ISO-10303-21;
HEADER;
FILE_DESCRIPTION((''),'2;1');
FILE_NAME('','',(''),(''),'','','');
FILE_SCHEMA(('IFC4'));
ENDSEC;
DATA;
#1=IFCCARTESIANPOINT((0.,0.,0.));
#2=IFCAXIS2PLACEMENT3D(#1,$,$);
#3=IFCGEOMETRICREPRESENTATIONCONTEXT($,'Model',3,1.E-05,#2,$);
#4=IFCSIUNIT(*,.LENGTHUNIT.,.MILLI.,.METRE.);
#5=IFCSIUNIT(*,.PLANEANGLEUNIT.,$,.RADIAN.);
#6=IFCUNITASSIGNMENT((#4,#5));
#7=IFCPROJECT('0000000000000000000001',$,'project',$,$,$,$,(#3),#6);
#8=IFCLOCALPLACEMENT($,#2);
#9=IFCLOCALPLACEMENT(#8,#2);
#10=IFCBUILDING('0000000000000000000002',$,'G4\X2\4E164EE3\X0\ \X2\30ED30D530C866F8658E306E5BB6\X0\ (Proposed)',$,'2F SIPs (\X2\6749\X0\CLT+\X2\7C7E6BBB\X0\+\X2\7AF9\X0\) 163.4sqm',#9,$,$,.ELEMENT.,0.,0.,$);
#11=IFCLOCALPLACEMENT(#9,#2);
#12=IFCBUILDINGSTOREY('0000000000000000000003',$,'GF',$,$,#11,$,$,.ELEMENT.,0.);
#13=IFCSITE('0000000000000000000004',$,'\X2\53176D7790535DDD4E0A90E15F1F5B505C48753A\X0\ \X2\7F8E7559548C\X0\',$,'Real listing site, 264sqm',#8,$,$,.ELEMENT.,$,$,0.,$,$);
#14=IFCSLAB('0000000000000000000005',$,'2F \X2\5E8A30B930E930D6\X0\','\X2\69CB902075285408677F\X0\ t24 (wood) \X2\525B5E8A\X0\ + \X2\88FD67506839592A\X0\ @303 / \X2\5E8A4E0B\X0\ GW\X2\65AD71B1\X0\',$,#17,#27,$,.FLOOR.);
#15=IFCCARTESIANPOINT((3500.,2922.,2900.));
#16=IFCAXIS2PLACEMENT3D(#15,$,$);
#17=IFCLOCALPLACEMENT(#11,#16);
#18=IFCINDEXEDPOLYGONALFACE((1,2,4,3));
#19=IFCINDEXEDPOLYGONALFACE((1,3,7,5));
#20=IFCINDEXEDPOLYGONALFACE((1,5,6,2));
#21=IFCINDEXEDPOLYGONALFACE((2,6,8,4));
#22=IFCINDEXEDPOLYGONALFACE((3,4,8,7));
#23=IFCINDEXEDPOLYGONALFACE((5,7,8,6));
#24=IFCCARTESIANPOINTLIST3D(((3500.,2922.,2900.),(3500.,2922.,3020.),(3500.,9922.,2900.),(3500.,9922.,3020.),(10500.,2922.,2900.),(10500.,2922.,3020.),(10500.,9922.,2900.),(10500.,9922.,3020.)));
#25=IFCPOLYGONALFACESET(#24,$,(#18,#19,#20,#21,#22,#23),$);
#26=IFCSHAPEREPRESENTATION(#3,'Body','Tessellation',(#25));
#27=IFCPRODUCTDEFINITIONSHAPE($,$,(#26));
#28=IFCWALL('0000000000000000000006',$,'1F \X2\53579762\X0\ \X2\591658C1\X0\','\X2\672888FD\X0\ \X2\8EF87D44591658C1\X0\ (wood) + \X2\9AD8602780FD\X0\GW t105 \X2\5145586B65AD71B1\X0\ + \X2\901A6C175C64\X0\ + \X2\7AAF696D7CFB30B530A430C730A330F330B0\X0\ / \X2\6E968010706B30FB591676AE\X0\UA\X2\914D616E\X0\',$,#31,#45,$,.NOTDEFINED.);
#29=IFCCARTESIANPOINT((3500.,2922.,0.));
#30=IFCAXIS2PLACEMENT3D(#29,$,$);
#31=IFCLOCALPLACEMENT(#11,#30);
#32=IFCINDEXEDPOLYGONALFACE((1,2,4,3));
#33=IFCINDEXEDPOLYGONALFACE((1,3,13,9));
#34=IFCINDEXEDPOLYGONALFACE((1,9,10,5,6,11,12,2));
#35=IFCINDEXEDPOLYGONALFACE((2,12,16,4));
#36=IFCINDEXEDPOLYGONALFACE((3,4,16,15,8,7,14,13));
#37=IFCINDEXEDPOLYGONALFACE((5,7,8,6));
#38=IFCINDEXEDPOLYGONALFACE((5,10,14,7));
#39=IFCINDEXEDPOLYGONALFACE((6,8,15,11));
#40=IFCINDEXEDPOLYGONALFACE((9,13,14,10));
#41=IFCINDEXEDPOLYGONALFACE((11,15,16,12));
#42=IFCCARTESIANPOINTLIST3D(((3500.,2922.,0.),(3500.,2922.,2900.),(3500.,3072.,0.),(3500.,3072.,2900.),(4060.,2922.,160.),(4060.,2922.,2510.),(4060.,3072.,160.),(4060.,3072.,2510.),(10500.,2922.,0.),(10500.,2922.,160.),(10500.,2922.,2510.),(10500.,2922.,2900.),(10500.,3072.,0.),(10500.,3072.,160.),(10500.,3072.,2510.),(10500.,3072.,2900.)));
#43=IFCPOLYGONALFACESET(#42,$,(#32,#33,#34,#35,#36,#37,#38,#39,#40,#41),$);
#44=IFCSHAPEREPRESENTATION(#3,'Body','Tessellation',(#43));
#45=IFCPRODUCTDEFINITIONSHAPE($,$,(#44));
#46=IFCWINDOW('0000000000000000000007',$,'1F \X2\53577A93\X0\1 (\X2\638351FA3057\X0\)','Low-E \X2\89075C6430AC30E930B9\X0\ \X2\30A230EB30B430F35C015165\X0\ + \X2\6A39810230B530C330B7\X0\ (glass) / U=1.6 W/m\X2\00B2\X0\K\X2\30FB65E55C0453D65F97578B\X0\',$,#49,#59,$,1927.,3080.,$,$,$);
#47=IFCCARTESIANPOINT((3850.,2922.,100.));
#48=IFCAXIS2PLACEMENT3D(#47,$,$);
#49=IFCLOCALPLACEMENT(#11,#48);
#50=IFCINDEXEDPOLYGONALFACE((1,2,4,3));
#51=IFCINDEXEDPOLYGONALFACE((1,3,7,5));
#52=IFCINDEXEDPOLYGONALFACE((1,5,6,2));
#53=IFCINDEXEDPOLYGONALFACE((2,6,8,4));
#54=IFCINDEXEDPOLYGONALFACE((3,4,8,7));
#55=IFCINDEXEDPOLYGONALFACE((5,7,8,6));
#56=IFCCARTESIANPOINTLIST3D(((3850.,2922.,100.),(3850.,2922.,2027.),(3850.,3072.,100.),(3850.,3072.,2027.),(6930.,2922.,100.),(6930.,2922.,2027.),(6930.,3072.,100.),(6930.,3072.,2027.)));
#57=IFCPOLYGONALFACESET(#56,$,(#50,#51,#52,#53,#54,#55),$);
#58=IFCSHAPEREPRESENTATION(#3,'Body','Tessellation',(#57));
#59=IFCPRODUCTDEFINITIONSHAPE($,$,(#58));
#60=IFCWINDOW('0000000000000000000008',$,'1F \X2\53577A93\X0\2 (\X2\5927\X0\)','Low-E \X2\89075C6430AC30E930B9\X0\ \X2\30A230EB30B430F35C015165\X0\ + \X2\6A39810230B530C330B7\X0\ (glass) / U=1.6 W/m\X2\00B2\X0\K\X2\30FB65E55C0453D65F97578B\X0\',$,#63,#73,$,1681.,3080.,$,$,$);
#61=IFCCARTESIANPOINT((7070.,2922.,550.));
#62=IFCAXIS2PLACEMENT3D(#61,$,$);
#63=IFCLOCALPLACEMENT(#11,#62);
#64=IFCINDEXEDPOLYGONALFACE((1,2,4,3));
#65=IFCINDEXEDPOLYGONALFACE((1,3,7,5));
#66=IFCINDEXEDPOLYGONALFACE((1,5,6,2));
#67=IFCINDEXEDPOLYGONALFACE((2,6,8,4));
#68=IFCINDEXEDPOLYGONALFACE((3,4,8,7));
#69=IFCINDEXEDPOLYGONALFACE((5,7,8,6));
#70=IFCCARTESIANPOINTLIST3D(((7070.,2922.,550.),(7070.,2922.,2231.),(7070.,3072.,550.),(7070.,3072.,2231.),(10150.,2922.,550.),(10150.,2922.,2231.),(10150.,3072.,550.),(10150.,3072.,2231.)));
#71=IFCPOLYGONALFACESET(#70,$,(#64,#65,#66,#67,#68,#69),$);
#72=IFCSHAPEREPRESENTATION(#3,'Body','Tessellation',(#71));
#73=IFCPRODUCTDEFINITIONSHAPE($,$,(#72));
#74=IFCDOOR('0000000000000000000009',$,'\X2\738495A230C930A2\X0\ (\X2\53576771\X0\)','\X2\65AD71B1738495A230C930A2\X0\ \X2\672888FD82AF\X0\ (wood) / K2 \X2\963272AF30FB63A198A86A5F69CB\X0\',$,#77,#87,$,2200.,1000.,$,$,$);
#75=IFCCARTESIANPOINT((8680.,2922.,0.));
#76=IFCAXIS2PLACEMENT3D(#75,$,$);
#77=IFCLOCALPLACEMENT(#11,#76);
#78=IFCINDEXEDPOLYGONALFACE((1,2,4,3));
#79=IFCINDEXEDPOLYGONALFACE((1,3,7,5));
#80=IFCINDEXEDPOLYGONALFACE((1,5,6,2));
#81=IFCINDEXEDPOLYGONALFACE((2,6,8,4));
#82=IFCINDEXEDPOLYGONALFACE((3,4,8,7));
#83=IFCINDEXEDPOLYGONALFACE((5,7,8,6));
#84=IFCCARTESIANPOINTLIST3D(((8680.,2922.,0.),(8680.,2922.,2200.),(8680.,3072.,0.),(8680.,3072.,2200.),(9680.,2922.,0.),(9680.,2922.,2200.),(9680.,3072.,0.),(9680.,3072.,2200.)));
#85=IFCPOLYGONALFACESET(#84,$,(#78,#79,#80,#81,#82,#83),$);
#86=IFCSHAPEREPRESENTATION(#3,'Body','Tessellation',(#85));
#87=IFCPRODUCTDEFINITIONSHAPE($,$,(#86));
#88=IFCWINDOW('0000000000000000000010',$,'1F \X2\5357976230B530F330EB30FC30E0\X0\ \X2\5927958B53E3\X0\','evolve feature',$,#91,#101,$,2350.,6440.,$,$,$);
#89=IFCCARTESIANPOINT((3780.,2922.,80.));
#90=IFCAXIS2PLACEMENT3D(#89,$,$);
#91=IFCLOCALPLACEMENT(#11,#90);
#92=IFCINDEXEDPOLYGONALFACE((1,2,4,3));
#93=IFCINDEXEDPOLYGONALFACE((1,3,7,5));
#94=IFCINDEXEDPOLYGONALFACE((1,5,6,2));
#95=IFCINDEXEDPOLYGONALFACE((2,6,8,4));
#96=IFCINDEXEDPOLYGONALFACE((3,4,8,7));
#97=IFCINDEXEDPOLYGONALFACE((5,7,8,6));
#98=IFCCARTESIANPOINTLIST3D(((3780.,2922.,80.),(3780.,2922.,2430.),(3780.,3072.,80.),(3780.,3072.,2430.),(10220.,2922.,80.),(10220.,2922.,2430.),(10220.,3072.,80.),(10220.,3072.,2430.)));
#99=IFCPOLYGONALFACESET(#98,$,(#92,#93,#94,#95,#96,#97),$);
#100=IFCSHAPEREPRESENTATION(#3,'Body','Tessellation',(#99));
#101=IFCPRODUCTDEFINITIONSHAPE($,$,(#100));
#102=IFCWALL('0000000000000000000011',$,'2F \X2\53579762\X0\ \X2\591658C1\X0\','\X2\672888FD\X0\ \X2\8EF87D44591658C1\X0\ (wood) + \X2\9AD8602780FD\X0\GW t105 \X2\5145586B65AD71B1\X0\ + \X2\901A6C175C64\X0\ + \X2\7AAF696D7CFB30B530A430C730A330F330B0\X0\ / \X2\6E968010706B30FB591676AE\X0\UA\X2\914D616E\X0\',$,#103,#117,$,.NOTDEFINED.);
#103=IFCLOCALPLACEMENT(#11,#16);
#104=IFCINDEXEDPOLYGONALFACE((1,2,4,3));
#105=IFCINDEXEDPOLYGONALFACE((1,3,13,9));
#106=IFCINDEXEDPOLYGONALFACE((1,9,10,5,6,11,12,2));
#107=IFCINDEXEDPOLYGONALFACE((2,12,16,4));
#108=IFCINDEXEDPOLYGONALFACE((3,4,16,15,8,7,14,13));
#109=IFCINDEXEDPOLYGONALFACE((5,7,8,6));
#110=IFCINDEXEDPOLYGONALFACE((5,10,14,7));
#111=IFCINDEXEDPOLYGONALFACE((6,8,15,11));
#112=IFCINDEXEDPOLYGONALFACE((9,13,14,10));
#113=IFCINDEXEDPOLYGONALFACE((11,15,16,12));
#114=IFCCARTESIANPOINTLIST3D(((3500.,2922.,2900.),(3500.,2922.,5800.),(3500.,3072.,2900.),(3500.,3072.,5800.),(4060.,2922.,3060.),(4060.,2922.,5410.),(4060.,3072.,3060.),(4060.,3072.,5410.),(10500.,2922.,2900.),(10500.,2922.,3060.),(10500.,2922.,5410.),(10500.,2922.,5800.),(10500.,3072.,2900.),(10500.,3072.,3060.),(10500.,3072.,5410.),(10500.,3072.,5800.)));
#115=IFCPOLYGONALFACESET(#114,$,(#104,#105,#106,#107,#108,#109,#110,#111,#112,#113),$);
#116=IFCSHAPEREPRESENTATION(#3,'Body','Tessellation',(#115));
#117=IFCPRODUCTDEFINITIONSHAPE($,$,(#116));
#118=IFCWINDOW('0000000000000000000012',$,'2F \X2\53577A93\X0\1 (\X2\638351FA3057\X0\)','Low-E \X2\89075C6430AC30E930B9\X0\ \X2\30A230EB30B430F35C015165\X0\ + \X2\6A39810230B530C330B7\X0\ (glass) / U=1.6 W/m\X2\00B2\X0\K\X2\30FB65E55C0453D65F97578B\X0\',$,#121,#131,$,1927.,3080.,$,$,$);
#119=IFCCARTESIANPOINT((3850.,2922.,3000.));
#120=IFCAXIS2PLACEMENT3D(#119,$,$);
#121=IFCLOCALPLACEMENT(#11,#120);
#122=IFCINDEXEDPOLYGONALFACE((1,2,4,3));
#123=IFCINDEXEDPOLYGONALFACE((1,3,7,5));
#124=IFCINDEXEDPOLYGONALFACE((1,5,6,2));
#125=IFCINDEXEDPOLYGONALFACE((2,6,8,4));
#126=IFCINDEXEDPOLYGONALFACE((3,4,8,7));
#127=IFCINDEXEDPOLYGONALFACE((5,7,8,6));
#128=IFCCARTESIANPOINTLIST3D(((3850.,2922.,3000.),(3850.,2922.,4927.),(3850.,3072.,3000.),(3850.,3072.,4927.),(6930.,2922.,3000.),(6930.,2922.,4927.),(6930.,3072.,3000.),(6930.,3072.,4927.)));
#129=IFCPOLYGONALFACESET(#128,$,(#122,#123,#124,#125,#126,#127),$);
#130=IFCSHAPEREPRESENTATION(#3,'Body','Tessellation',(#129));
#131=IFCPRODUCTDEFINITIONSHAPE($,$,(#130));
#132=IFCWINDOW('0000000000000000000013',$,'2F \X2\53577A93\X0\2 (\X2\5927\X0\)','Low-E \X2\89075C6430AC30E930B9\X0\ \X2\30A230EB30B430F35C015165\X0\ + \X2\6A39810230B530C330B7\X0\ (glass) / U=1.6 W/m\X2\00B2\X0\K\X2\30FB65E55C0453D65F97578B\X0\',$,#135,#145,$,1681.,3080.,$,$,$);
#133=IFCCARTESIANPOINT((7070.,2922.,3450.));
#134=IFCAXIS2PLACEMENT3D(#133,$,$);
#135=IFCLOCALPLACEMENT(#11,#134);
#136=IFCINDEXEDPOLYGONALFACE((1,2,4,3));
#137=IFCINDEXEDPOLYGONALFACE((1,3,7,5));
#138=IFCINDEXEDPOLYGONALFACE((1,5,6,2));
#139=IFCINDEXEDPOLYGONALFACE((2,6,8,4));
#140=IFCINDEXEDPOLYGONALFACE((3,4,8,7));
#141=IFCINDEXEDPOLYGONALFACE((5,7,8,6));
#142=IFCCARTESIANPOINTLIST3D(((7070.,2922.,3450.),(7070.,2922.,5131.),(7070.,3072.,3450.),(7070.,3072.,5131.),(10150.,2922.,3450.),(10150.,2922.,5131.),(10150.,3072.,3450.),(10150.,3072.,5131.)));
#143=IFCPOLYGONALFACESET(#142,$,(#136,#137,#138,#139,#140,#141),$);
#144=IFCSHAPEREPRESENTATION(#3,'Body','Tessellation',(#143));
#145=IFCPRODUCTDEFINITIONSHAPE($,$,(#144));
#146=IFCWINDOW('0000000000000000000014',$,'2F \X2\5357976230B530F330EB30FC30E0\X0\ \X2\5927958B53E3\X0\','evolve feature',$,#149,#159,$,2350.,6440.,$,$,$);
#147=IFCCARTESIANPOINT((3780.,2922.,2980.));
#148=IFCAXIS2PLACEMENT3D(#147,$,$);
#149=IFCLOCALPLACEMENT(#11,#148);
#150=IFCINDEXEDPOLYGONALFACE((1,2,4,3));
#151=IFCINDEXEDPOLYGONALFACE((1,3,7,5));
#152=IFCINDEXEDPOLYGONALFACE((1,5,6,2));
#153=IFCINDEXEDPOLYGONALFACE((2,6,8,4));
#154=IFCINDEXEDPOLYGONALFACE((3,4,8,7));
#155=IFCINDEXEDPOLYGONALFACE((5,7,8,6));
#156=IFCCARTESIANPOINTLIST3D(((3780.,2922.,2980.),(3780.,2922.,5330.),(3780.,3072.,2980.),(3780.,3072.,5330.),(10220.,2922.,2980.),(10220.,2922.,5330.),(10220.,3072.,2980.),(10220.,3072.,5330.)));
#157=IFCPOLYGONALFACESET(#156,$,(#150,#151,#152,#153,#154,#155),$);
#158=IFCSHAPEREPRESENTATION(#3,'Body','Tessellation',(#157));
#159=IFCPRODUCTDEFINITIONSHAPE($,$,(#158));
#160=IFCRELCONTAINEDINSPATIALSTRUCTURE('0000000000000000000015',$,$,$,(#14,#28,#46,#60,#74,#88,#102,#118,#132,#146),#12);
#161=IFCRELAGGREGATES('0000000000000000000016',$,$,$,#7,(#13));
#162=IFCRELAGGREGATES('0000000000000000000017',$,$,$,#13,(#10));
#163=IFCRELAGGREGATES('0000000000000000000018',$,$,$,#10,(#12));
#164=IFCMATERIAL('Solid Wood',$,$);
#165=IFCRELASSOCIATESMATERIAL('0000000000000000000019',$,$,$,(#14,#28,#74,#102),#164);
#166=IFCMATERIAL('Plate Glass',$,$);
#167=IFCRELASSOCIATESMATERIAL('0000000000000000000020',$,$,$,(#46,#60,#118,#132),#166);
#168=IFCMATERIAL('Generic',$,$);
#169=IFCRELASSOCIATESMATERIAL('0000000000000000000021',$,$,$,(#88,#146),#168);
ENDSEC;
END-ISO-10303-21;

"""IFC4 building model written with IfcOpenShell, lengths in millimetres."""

from ifc_helpers import new_model, si_unit, frame, frame_2d, origin, place, context, project, spatial, rectangle, extrude, material, element, fill, save


model = new_model("IFC4")

# Units and contexts
model_context = context("Model", 3, precision=1e-05, world=origin())
ifc_project = project(units=[si_unit("LENGTHUNIT", "METRE", prefix="MILLI"), si_unit("PLANEANGLEUNIT", "RADIAN")], contexts=[model_context])

# Site, building, storey
site_placement = place(None, origin())
site = spatial("IfcSite", under=ifc_project, at=site_placement, Name="北海道川上郡弟子屈町 美留和", ObjectType="Real listing site, 264sqm", CompositionType="ELEMENT", RefElevation=0.0)
building_placement = place(site_placement, origin())
building = spatial("IfcBuilding", under=site, at=building_placement, Name="G4世代 ロフト書斎の家 (Proposed)", ObjectType="2F SIPs (杉CLT+籾殻+竹) 163.4sqm", CompositionType="ELEMENT", ElevationOfRefHeight=0.0, ElevationOfTerrain=0.0)
storey_placement = place(building_placement, origin())
storey = spatial("IfcBuildingStorey", under=building, at=storey_placement, Name="GF", CompositionType="ELEMENT", Elevation=0.0)

# Slab
ifc_material_1 = material(Name="Solid Wood")
slab_1_placement = place(storey_placement, frame((3500.0, 2922.0, 2900.0)))
element("IfcSlab", 1, at=slab_1_placement, inside=storey, material=ifc_material_1, Name="2F 床スラブ", Description="構造用合板 t24 (wood) 剛床 + 製材根太 @303 / 床下 GW断熱", PredefinedType="FLOOR", context=model_context, shape_type="SweptSolid", body=[
    extrude(rectangle(XDim=7000.0, YDim=7000.0, at=frame_2d((3500.0, 3500.0))), frame((3500.0, 2922.0, 2900.0)), (0.0, 0.0, 1.0), 120.0),
])
ifc_material_2 = material(Name="Generic")

# Wall, openings, windows, door
wall_1_placement = place(storey_placement, frame((3500.0, 2922.0, 0.0)))
wall_1 = element("IfcWall", 2, at=wall_1_placement, inside=storey, material=ifc_material_1, Name="1F 南面 外壁", Description="木製 軸組外壁 (wood) + 高性能GW t105 充填断熱 + 通気層 + 窯業系サイディング / 準耐火・外皮UA配慮", PredefinedType="NOTDEFINED", context=model_context, shape_type="SweptSolid", body=[
    extrude(rectangle(XDim=7000.0, YDim=150.0, at=frame_2d((3500.0, 75.0))), frame((3500.0, 2922.0, 0.0)), (0.0, 0.0, 1.0), 2900.0),
])
opening_1_placement = place(storey_placement, frame((3850.0, 2922.0, 100.0)))
opening_1 = element("IfcOpeningElement", 3, at=opening_1_placement, cuts=wall_1, PredefinedType="NOTDEFINED", context=model_context, shape_type="SweptSolid", body=[
    extrude(rectangle(XDim=3080.0, YDim=150.0, at=frame_2d((1540.0, 75.0))), frame((3850.0, 2922.0, 100.0)), (0.0, 0.0, 1.0), 1927.0),
])
opening_2_placement = place(storey_placement, frame((7070.0, 2922.0, 550.0)))
opening_2 = element("IfcOpeningElement", 4, at=opening_2_placement, cuts=wall_1, PredefinedType="NOTDEFINED", context=model_context, shape_type="SweptSolid", body=[
    extrude(rectangle(XDim=3080.0, YDim=150.0, at=frame_2d((1540.0, 75.0))), frame((7070.0, 2922.0, 550.0)), (0.0, 0.0, 1.0), 1681.0),
])
opening_3_placement = place(storey_placement, frame((8680.0, 2922.0, 0.0)))
opening_3 = element("IfcOpeningElement", 5, at=opening_3_placement, cuts=wall_1, PredefinedType="NOTDEFINED", context=model_context, shape_type="SweptSolid", body=[
    extrude(rectangle(XDim=1000.0, YDim=150.0, at=frame_2d((500.0, 75.0))), frame((8680.0, 2922.0, 0.0)), (0.0, 0.0, 1.0), 2200.0),
])
opening_4_placement = place(storey_placement, frame((3780.0, 2922.0, 80.0)))
opening_4 = element("IfcOpeningElement", 6, at=opening_4_placement, cuts=wall_1, PredefinedType="NOTDEFINED", context=model_context, shape_type="SweptSolid", body=[
    extrude(rectangle(XDim=6440.0, YDim=150.0, at=frame_2d((3220.0, 75.0))), frame((3780.0, 2922.0, 80.0)), (0.0, 0.0, 1.0), 2350.0),
])
ifc_material_3 = material(Name="Plate Glass")
window_1_placement = place(storey_placement, frame((3850.0, 2922.0, 100.0)))
window_1 = element("IfcWindow", 7, at=window_1_placement, inside=storey, material=ifc_material_3, Name="1F 南窓1 (掃出し)", Description="Low-E 複層ガラス アルゴン封入 + 樹脂サッシ (glass) / U=1.6 W/m²K・日射取得型", OverallHeight=1927.0, OverallWidth=3080.0, context=model_context, shape_type="SweptSolid", body=[
    extrude(rectangle(XDim=3080.0, YDim=150.0, at=frame_2d((1540.0, 75.0))), frame((3850.0, 2922.0, 100.0)), (0.0, 0.0, 1.0), 1927.0),
])
fill(opening_1, window_1)
window_2_placement = place(storey_placement, frame((7070.0, 2922.0, 550.0)))
window_2 = element("IfcWindow", 8, at=window_2_placement, inside=storey, material=ifc_material_3, Name="1F 南窓2 (大)", Description="Low-E 複層ガラス アルゴン封入 + 樹脂サッシ (glass) / U=1.6 W/m²K・日射取得型", OverallHeight=1681.0, OverallWidth=3080.0, context=model_context, shape_type="SweptSolid", body=[
    extrude(rectangle(XDim=3080.0, YDim=150.0, at=frame_2d((1540.0, 75.0))), frame((7070.0, 2922.0, 550.0)), (0.0, 0.0, 1.0), 1681.0),
])
fill(opening_2, window_2)
door_placement = place(storey_placement, frame((8680.0, 2922.0, 0.0)))
door = element("IfcDoor", 9, at=door_placement, inside=storey, material=ifc_material_1, Name="玄関ドア (南東)", Description="断熱玄関ドア 木製芯 (wood) / K2 防犯・採風機構", OverallHeight=2200.0, OverallWidth=1000.0, context=model_context, shape_type="SweptSolid", body=[
    extrude(rectangle(XDim=1000.0, YDim=150.0, at=frame_2d((500.0, 75.0))), frame((8680.0, 2922.0, 0.0)), (0.0, 0.0, 1.0), 2200.0),
])
fill(opening_3, door)
window_3_placement = place(storey_placement, frame((3780.0, 2922.0, 80.0)))
window_3 = element("IfcWindow", 10, at=window_3_placement, inside=storey, material=ifc_material_2, Name="1F 南面サンルーム 大開口", Description="evolve feature", OverallHeight=2350.0, OverallWidth=6440.0, context=model_context, shape_type="SweptSolid", body=[
    extrude(rectangle(XDim=6440.0, YDim=150.0, at=frame_2d((3220.0, 75.0))), frame((3780.0, 2922.0, 80.0)), (0.0, 0.0, 1.0), 2350.0),
])
fill(opening_4, window_3)

# Wall, openings, windows
wall_2_placement = place(storey_placement, frame((3500.0, 2922.0, 2900.0)))
wall_2 = element("IfcWall", 11, at=wall_2_placement, inside=storey, material=ifc_material_1, Name="2F 南面 外壁", Description="木製 軸組外壁 (wood) + 高性能GW t105 充填断熱 + 通気層 + 窯業系サイディング / 準耐火・外皮UA配慮", PredefinedType="NOTDEFINED", context=model_context, shape_type="SweptSolid", body=[
    extrude(rectangle(XDim=7000.0, YDim=150.0, at=frame_2d((3500.0, 75.0))), frame((3500.0, 2922.0, 2900.0)), (0.0, 0.0, 1.0), 2900.0),
])
opening_5_placement = place(storey_placement, frame((3850.0, 2922.0, 3000.0)))
opening_5 = element("IfcOpeningElement", 12, at=opening_5_placement, cuts=wall_2, PredefinedType="NOTDEFINED", context=model_context, shape_type="SweptSolid", body=[
    extrude(rectangle(XDim=3080.0, YDim=150.0, at=frame_2d((1540.0, 75.0))), frame((3850.0, 2922.0, 3000.0)), (0.0, 0.0, 1.0), 1927.0),
])
opening_6_placement = place(storey_placement, frame((7070.0, 2922.0, 3450.0)))
opening_6 = element("IfcOpeningElement", 13, at=opening_6_placement, cuts=wall_2, PredefinedType="NOTDEFINED", context=model_context, shape_type="SweptSolid", body=[
    extrude(rectangle(XDim=3080.0, YDim=150.0, at=frame_2d((1540.0, 75.0))), frame((7070.0, 2922.0, 3450.0)), (0.0, 0.0, 1.0), 1681.0),
])
opening_7_placement = place(storey_placement, frame((3780.0, 2922.0, 2980.0)))
opening_7 = element("IfcOpeningElement", 14, at=opening_7_placement, cuts=wall_2, PredefinedType="NOTDEFINED", context=model_context, shape_type="SweptSolid", body=[
    extrude(rectangle(XDim=6440.0, YDim=150.0, at=frame_2d((3220.0, 75.0))), frame((3780.0, 2922.0, 2980.0)), (0.0, 0.0, 1.0), 2350.0),
])
window_4_placement = place(storey_placement, frame((3850.0, 2922.0, 3000.0)))
window_4 = element("IfcWindow", 15, at=window_4_placement, inside=storey, material=ifc_material_3, Name="2F 南窓1 (掃出し)", Description="Low-E 複層ガラス アルゴン封入 + 樹脂サッシ (glass) / U=1.6 W/m²K・日射取得型", OverallHeight=1927.0, OverallWidth=3080.0, context=model_context, shape_type="SweptSolid", body=[
    extrude(rectangle(XDim=3080.0, YDim=150.0, at=frame_2d((1540.0, 75.0))), frame((3850.0, 2922.0, 3000.0)), (0.0, 0.0, 1.0), 1927.0),
])
fill(opening_5, window_4)
window_5_placement = place(storey_placement, frame((7070.0, 2922.0, 3450.0)))
window_5 = element("IfcWindow", 16, at=window_5_placement, inside=storey, material=ifc_material_3, Name="2F 南窓2 (大)", Description="Low-E 複層ガラス アルゴン封入 + 樹脂サッシ (glass) / U=1.6 W/m²K・日射取得型", OverallHeight=1681.0, OverallWidth=3080.0, context=model_context, shape_type="SweptSolid", body=[
    extrude(rectangle(XDim=3080.0, YDim=150.0, at=frame_2d((1540.0, 75.0))), frame((7070.0, 2922.0, 3450.0)), (0.0, 0.0, 1.0), 1681.0),
])
fill(opening_6, window_5)
window_6_placement = place(storey_placement, frame((3780.0, 2922.0, 2980.0)))
window_6 = element("IfcWindow", 17, at=window_6_placement, inside=storey, material=ifc_material_2, Name="2F 南面サンルーム 大開口", Description="evolve feature", OverallHeight=2350.0, OverallWidth=6440.0, context=model_context, shape_type="SweptSolid", body=[
    extrude(rectangle(XDim=6440.0, YDim=150.0, at=frame_2d((3220.0, 75.0))), frame((3780.0, 2922.0, 2980.0)), (0.0, 0.0, 1.0), 2350.0),
])
fill(opening_7, window_6)

save(model, "model.ifc")
